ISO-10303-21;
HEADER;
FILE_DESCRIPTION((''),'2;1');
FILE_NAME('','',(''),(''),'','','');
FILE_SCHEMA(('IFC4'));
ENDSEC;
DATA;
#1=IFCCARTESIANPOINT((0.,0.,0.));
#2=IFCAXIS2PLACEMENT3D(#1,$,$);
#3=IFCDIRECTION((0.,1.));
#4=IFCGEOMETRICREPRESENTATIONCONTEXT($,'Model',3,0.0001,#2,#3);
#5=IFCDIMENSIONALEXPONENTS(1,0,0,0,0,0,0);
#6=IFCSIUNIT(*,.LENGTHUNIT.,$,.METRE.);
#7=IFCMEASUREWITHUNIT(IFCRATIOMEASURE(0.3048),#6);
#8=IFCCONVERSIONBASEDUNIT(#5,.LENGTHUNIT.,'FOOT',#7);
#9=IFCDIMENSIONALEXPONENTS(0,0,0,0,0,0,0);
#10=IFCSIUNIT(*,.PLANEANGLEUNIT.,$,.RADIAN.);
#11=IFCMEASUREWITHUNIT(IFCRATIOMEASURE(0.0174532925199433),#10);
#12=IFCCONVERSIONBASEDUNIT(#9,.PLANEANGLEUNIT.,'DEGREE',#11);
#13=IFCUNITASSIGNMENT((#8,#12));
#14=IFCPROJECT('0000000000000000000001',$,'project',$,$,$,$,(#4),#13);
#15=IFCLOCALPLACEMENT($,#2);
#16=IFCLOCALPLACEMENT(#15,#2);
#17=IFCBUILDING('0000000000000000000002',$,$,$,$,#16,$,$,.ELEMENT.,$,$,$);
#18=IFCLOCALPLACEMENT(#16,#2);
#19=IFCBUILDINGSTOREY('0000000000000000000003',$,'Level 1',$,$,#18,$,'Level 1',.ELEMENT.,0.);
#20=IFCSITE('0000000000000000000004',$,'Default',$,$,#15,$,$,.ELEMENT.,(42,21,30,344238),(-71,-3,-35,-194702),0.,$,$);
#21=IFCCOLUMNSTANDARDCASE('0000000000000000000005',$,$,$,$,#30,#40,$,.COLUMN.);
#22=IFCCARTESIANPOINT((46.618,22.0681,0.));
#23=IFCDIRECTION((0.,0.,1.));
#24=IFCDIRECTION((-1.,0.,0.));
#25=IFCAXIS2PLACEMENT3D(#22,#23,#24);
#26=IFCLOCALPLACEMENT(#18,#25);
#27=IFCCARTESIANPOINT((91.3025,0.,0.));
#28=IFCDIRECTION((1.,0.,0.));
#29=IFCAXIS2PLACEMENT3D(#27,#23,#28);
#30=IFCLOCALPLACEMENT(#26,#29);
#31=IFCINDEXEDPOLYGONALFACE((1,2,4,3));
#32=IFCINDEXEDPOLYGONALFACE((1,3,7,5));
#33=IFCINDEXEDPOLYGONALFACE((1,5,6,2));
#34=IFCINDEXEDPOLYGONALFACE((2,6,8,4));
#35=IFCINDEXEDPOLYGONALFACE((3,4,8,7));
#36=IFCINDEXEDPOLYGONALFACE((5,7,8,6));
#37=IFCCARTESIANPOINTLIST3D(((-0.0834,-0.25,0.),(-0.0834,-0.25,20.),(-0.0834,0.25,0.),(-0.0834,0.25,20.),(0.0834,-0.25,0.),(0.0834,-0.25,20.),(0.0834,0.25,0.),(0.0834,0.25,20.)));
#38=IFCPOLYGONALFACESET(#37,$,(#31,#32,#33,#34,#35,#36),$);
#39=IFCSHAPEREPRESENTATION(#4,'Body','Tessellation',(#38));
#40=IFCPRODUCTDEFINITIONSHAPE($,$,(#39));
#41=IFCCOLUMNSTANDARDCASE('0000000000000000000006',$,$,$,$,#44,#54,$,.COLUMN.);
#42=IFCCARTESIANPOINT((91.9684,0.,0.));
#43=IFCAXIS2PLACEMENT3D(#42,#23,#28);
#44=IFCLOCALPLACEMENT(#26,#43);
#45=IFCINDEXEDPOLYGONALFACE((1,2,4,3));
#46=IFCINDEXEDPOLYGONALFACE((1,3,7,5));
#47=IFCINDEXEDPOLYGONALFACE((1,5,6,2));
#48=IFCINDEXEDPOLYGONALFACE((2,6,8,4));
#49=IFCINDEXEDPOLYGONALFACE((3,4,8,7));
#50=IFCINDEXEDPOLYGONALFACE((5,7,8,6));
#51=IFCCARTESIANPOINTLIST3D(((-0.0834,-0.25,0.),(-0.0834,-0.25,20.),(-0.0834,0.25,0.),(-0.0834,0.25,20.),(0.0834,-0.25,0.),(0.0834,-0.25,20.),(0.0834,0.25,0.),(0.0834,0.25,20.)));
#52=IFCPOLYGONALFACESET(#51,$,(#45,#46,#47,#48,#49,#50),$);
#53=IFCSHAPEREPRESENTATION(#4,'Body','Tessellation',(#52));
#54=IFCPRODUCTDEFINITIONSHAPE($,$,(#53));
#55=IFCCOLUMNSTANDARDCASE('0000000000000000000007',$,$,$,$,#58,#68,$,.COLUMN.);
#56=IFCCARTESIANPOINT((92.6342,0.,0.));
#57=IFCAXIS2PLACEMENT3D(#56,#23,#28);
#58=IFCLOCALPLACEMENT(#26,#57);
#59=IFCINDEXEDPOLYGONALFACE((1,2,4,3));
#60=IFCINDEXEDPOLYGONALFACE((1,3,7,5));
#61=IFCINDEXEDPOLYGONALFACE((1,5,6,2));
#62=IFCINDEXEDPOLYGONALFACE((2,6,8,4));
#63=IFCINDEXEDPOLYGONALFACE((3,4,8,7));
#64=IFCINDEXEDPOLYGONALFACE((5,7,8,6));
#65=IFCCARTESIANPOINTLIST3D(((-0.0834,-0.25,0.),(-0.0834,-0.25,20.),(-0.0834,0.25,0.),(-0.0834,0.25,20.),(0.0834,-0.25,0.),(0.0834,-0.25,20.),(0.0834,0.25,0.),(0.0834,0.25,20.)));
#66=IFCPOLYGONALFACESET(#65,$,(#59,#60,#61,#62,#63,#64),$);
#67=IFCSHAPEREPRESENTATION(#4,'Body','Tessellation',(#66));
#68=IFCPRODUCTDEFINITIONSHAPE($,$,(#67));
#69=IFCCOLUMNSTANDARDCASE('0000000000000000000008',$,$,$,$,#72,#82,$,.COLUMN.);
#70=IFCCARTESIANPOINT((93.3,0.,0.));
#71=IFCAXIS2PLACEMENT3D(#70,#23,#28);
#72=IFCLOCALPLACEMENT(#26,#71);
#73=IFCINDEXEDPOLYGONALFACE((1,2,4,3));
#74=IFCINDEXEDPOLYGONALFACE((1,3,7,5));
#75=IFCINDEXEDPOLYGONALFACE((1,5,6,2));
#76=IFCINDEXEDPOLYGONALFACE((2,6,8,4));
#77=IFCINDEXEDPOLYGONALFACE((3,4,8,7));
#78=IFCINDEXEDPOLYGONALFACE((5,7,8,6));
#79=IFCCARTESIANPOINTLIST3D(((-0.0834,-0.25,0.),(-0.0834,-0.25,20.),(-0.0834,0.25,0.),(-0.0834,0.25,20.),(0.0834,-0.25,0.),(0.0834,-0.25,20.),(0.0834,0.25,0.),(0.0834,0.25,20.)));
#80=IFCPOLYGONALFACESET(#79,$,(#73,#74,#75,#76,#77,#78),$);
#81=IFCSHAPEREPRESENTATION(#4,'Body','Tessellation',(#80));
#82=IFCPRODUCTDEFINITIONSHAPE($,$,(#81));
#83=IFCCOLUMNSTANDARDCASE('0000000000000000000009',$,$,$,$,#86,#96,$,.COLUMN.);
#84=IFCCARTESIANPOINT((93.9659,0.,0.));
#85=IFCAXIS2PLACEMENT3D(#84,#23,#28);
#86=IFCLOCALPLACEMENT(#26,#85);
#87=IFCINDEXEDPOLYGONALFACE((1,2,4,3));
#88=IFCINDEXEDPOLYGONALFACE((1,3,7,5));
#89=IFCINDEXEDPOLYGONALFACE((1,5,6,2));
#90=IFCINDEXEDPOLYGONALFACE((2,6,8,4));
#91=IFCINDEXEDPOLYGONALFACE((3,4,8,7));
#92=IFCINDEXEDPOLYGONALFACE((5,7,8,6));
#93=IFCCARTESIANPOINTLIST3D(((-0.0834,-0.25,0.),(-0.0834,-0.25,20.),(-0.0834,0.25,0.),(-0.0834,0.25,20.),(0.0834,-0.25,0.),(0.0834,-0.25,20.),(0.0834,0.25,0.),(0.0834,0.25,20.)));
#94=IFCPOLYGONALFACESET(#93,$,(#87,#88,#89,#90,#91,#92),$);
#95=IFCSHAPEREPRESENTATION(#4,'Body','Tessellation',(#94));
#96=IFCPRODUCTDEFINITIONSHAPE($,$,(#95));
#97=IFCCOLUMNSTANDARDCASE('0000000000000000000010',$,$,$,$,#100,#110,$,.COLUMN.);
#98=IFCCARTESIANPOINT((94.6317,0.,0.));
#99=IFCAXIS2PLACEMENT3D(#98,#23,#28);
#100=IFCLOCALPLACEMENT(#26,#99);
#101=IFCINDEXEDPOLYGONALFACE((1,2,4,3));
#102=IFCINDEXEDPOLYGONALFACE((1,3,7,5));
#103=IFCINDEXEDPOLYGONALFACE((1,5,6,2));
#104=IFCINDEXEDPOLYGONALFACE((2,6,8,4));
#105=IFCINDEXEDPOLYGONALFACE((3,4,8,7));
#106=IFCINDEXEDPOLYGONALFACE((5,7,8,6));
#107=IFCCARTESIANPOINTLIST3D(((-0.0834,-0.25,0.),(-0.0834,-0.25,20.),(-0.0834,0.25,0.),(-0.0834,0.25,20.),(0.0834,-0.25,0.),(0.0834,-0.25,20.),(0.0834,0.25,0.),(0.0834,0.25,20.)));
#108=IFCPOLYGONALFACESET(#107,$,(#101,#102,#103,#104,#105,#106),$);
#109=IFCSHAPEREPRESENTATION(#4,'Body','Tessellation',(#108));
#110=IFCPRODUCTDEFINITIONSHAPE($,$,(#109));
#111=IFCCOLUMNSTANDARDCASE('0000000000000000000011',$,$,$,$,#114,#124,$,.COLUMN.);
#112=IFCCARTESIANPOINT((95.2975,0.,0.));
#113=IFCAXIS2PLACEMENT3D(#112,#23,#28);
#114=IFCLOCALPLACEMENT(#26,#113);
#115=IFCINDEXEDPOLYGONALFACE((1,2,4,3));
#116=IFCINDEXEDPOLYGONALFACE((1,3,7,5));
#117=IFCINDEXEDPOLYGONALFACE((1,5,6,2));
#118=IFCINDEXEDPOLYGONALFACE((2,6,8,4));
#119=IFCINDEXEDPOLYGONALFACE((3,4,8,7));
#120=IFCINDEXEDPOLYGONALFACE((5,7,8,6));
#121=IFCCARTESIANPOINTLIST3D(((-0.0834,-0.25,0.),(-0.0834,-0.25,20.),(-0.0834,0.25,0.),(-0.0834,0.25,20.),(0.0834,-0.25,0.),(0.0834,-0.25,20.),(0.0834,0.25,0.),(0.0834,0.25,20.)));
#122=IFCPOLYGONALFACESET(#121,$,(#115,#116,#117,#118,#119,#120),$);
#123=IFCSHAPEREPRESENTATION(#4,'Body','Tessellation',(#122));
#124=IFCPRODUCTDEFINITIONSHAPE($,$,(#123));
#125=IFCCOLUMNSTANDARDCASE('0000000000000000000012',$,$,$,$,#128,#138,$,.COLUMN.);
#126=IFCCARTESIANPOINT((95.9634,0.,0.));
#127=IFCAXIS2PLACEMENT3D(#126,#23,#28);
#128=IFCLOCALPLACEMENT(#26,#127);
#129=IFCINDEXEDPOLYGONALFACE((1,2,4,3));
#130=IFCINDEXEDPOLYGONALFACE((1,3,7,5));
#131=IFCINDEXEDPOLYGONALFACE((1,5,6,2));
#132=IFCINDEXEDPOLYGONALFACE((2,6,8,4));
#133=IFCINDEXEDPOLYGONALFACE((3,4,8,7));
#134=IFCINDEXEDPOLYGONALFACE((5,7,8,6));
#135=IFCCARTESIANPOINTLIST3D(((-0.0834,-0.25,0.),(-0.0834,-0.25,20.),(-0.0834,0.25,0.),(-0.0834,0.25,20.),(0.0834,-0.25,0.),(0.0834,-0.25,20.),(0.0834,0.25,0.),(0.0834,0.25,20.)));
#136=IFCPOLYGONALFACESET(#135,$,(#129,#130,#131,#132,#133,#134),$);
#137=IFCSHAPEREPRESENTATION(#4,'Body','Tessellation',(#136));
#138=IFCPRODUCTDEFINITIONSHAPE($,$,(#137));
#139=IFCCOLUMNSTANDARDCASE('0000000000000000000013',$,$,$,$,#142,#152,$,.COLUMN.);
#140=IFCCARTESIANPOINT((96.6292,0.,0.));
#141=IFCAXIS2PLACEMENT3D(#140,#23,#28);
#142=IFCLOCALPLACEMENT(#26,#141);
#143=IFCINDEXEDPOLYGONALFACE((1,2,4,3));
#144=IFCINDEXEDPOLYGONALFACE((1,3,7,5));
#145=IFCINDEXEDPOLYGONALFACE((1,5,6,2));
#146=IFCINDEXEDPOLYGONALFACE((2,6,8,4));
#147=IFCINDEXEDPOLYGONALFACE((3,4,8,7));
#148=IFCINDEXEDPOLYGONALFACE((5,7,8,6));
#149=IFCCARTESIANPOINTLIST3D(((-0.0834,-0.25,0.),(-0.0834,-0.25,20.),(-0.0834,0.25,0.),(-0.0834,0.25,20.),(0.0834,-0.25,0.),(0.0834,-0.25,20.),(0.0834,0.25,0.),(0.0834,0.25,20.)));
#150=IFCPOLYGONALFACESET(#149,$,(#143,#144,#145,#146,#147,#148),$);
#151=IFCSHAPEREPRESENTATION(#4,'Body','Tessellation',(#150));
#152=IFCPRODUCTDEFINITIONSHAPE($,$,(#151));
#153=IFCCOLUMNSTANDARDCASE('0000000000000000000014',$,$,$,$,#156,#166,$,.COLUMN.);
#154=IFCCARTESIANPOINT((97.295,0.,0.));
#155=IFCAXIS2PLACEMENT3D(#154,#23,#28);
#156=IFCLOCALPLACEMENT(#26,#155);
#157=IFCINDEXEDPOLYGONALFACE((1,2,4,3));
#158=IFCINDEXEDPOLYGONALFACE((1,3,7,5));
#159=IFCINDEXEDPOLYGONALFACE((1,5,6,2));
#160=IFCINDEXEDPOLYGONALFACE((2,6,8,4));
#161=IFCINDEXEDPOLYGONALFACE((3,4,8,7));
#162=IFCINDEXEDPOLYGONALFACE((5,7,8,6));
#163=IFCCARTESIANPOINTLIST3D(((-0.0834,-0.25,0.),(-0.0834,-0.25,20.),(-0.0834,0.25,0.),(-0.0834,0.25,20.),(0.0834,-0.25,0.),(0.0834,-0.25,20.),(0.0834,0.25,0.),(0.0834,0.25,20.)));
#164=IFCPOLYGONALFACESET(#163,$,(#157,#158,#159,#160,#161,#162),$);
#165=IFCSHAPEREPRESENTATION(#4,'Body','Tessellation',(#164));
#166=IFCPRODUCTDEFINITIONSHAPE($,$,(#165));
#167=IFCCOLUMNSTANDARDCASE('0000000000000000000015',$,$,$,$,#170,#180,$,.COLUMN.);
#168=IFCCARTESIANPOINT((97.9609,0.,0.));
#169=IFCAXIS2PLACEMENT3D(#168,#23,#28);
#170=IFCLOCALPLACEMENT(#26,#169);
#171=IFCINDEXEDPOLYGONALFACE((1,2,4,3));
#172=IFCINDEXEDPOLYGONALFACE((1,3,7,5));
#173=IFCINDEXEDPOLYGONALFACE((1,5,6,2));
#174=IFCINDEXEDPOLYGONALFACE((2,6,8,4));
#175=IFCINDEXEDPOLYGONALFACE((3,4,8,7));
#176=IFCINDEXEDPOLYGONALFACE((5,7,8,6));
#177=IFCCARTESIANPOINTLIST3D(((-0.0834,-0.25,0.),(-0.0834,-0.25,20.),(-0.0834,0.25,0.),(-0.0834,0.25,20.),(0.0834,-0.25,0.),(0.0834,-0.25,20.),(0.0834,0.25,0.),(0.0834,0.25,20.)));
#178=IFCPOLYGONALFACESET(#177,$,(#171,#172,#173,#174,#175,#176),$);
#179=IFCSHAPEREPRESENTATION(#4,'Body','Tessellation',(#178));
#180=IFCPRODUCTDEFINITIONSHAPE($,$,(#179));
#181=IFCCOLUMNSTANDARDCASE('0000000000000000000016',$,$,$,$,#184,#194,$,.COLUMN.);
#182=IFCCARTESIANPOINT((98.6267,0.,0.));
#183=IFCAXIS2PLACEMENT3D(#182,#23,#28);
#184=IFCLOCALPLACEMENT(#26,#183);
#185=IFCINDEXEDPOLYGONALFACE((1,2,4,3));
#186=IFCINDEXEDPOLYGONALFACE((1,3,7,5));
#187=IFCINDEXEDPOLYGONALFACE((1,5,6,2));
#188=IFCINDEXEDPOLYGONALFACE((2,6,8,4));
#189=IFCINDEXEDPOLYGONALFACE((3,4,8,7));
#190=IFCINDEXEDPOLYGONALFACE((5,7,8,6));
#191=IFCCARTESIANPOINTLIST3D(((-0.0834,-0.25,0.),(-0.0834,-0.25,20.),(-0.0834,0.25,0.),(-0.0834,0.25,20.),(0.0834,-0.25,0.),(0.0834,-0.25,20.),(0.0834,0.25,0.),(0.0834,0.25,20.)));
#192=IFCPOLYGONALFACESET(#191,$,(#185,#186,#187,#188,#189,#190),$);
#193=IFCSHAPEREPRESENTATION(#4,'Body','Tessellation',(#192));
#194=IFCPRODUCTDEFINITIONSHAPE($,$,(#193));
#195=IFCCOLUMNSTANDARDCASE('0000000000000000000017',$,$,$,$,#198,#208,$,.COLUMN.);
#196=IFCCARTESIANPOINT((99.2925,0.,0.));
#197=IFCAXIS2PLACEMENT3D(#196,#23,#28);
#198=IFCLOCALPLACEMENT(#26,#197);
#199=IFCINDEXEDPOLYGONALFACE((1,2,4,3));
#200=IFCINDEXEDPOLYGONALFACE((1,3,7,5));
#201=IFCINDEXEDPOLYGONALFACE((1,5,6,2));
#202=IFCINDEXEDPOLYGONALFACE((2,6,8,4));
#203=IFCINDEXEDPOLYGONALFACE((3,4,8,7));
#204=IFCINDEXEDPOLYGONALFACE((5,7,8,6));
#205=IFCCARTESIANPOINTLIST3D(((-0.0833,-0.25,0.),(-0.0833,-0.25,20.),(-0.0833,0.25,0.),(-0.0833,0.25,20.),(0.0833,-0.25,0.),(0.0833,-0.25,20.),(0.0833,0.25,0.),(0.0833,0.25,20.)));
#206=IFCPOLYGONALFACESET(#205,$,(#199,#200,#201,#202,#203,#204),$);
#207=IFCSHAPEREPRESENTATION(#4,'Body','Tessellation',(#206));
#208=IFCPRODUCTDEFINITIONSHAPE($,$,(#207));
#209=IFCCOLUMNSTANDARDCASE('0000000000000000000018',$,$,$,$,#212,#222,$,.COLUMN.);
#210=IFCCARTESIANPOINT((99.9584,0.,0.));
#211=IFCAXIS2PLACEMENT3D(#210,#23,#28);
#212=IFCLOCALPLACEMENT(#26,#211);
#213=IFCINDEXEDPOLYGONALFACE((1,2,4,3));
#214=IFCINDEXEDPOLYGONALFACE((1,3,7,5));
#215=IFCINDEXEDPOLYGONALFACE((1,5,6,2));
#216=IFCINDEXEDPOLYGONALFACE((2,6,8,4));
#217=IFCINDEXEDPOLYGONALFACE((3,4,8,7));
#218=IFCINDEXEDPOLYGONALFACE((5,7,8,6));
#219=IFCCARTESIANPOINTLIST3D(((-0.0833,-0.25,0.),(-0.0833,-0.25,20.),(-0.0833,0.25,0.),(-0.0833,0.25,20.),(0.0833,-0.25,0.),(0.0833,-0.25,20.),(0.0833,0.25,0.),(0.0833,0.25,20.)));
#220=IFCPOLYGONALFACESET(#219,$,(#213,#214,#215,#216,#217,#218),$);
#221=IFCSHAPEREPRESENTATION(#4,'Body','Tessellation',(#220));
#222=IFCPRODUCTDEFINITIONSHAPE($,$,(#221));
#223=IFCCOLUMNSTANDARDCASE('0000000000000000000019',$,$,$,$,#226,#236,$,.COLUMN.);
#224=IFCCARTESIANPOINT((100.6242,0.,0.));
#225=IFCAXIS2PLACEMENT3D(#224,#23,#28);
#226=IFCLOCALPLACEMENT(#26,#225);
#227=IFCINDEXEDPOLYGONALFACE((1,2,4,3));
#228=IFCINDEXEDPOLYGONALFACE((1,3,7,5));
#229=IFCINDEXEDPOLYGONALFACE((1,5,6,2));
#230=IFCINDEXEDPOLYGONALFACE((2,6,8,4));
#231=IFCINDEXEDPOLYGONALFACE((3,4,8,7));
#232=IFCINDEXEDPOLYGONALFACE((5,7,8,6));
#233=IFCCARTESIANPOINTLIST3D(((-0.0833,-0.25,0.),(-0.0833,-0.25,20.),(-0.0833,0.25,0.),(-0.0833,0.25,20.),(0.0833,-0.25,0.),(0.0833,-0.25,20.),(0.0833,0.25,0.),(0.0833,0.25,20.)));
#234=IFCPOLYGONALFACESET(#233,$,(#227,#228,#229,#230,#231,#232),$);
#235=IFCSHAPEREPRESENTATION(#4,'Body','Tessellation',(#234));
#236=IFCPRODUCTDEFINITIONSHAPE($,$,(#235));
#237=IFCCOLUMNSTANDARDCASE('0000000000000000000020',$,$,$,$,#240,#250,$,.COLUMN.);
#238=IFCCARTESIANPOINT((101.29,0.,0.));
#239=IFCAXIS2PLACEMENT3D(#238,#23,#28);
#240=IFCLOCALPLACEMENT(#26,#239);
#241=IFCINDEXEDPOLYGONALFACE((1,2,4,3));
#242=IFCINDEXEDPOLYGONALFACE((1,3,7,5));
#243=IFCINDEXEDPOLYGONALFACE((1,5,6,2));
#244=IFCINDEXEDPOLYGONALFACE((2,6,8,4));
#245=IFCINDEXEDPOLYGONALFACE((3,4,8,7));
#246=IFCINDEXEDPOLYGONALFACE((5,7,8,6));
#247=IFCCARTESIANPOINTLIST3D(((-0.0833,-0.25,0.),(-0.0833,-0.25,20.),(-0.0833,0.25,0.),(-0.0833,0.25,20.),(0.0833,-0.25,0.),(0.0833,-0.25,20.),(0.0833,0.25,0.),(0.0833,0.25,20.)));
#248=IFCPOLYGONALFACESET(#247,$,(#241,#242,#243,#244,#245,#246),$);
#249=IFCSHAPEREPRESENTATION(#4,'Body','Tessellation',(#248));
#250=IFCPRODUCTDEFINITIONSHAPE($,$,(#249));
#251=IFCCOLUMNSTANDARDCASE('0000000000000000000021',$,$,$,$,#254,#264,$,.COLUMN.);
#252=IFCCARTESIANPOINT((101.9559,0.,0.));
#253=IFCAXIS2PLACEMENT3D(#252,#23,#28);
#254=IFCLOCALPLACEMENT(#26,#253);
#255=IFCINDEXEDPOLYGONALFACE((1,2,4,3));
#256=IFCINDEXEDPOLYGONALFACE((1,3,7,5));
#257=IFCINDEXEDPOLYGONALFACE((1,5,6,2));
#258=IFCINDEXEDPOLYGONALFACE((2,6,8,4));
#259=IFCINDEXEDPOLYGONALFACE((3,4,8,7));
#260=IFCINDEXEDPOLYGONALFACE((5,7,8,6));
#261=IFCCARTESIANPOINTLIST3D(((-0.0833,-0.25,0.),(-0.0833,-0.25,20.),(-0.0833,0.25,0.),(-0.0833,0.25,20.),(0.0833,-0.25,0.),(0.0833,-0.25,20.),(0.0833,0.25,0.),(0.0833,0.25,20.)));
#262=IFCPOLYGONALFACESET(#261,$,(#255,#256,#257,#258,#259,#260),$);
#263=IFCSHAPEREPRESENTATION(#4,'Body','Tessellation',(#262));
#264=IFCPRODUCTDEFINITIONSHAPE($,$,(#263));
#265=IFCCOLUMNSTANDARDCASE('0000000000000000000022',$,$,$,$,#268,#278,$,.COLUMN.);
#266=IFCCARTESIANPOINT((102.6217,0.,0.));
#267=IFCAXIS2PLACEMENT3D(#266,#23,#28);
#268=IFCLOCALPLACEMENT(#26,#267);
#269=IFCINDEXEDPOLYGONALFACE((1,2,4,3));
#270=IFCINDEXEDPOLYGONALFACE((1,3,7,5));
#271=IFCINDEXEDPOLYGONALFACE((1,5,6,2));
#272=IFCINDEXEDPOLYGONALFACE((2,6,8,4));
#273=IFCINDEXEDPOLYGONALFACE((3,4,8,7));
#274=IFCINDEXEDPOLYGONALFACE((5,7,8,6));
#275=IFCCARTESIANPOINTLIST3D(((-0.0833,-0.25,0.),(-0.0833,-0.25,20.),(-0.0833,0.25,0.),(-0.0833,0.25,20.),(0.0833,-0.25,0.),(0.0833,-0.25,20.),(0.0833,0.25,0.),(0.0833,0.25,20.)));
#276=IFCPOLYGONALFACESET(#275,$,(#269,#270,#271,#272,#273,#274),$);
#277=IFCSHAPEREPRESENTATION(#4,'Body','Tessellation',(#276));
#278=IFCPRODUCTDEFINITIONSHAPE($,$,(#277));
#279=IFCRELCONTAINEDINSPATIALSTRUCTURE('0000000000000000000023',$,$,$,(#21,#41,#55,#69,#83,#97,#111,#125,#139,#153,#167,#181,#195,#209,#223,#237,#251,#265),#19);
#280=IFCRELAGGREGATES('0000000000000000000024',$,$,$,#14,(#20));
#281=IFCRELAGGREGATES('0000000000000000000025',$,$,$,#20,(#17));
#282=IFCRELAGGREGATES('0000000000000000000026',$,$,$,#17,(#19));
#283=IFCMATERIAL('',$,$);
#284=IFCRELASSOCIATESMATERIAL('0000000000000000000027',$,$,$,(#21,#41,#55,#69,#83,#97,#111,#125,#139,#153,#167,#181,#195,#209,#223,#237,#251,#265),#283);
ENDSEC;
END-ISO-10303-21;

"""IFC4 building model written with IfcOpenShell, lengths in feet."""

from ifc_helpers import new_model, entity, si_unit, converted_unit, direction, frame, origin, place, context, project, spatial, rectangle, extrude, material, element, save


model = new_model("IFC4")

# Units and contexts
model_context = context("Model", 3, precision=0.0001, world=origin(), true_north=direction((0.0, 1.0)))
ifc_project = project(units=[converted_unit("LENGTHUNIT", "FOOT", entity("IfcRatioMeasure", 0.3048), si_unit("LENGTHUNIT", "METRE"), dimensions=[1, 0, 0, 0, 0, 0, 0]), converted_unit("PLANEANGLEUNIT", "DEGREE", entity("IfcRatioMeasure", 0.0174532925199433), si_unit("PLANEANGLEUNIT", "RADIAN"), dimensions=[0, 0, 0, 0, 0, 0, 0])], contexts=[model_context])

# Site, building, storey
site_placement = place(None, origin())
site = spatial("IfcSite", under=ifc_project, at=site_placement, Name="Default", CompositionType="ELEMENT", RefLatitude=(42, 21, 30, 344238), RefLongitude=(-71, -3, -35, -194702), RefElevation=0.0)
building_placement = place(site_placement, origin())
building = spatial("IfcBuilding", under=site, at=building_placement, CompositionType="ELEMENT")
storey_placement = place(building_placement, origin())
storey = spatial("IfcBuildingStorey", under=building, at=storey_placement, Name="Level 1", LongName="Level 1", CompositionType="ELEMENT", Elevation=0.0)

# Columns
ifc_material_1 = material(Name="")
placement_1 = place(storey_placement, frame((46.618, 22.0681, 0.0), z_axis=(0.0, 0.0, 1.0), x_axis=(-1.0, 0.0, 0.0)))
for number, where, z_axis, x_axis in (
    (1, (91.3025, 0.0, 0.0), (0.0, 0.0, 1.0), (1.0, 0.0, 0.0)),
    (2, (91.9684, 0.0, 0.0), (0.0, 0.0, 1.0), (1.0, 0.0, 0.0)),
    (3, (92.6342, 0.0, 0.0), (0.0, 0.0, 1.0), (1.0, 0.0, 0.0)),
    (4, (93.3, 0.0, 0.0), (0.0, 0.0, 1.0), (1.0, 0.0, 0.0)),
    (5, (93.9659, 0.0, 0.0), (0.0, 0.0, 1.0), (1.0, 0.0, 0.0)),
    (6, (94.6317, 0.0, 0.0), (0.0, 0.0, 1.0), (1.0, 0.0, 0.0)),
    (7, (95.2975, 0.0, 0.0), (0.0, 0.0, 1.0), (1.0, 0.0, 0.0)),
    (8, (95.9634, 0.0, 0.0), (0.0, 0.0, 1.0), (1.0, 0.0, 0.0)),
    (9, (96.6292, 0.0, 0.0), (0.0, 0.0, 1.0), (1.0, 0.0, 0.0)),
    (10, (97.295, 0.0, 0.0), (0.0, 0.0, 1.0), (1.0, 0.0, 0.0)),
    (11, (97.9609, 0.0, 0.0), (0.0, 0.0, 1.0), (1.0, 0.0, 0.0)),
    (12, (98.6267, 0.0, 0.0), (0.0, 0.0, 1.0), (1.0, 0.0, 0.0)),
    (13, (99.2925, 0.0, 0.0), (0.0, 0.0, 1.0), (1.0, 0.0, 0.0)),
    (14, (99.9584, 0.0, 0.0), (0.0, 0.0, 1.0), (1.0, 0.0, 0.0)),
    (15, (100.6242, 0.0, 0.0), (0.0, 0.0, 1.0), (1.0, 0.0, 0.0)),
    (16, (101.29, 0.0, 0.0), (0.0, 0.0, 1.0), (1.0, 0.0, 0.0)),
    (17, (101.9559, 0.0, 0.0), (0.0, 0.0, 1.0), (1.0, 0.0, 0.0)),
    (18, (102.6217, 0.0, 0.0), (0.0, 0.0, 1.0), (1.0, 0.0, 0.0)),
):
    element("IfcColumnStandardCase", number, at=place(placement_1, frame(where, z_axis=z_axis, x_axis=x_axis)), inside=storey, material=ifc_material_1, PredefinedType="COLUMN", context=model_context, shape_type="SweptSolid", body=[
        extrude(rectangle(XDim=0.1667, YDim=0.5), origin(), (0.0, 0.0, 1.0), 20.0),
    ])

save(model, "model.ifc")
